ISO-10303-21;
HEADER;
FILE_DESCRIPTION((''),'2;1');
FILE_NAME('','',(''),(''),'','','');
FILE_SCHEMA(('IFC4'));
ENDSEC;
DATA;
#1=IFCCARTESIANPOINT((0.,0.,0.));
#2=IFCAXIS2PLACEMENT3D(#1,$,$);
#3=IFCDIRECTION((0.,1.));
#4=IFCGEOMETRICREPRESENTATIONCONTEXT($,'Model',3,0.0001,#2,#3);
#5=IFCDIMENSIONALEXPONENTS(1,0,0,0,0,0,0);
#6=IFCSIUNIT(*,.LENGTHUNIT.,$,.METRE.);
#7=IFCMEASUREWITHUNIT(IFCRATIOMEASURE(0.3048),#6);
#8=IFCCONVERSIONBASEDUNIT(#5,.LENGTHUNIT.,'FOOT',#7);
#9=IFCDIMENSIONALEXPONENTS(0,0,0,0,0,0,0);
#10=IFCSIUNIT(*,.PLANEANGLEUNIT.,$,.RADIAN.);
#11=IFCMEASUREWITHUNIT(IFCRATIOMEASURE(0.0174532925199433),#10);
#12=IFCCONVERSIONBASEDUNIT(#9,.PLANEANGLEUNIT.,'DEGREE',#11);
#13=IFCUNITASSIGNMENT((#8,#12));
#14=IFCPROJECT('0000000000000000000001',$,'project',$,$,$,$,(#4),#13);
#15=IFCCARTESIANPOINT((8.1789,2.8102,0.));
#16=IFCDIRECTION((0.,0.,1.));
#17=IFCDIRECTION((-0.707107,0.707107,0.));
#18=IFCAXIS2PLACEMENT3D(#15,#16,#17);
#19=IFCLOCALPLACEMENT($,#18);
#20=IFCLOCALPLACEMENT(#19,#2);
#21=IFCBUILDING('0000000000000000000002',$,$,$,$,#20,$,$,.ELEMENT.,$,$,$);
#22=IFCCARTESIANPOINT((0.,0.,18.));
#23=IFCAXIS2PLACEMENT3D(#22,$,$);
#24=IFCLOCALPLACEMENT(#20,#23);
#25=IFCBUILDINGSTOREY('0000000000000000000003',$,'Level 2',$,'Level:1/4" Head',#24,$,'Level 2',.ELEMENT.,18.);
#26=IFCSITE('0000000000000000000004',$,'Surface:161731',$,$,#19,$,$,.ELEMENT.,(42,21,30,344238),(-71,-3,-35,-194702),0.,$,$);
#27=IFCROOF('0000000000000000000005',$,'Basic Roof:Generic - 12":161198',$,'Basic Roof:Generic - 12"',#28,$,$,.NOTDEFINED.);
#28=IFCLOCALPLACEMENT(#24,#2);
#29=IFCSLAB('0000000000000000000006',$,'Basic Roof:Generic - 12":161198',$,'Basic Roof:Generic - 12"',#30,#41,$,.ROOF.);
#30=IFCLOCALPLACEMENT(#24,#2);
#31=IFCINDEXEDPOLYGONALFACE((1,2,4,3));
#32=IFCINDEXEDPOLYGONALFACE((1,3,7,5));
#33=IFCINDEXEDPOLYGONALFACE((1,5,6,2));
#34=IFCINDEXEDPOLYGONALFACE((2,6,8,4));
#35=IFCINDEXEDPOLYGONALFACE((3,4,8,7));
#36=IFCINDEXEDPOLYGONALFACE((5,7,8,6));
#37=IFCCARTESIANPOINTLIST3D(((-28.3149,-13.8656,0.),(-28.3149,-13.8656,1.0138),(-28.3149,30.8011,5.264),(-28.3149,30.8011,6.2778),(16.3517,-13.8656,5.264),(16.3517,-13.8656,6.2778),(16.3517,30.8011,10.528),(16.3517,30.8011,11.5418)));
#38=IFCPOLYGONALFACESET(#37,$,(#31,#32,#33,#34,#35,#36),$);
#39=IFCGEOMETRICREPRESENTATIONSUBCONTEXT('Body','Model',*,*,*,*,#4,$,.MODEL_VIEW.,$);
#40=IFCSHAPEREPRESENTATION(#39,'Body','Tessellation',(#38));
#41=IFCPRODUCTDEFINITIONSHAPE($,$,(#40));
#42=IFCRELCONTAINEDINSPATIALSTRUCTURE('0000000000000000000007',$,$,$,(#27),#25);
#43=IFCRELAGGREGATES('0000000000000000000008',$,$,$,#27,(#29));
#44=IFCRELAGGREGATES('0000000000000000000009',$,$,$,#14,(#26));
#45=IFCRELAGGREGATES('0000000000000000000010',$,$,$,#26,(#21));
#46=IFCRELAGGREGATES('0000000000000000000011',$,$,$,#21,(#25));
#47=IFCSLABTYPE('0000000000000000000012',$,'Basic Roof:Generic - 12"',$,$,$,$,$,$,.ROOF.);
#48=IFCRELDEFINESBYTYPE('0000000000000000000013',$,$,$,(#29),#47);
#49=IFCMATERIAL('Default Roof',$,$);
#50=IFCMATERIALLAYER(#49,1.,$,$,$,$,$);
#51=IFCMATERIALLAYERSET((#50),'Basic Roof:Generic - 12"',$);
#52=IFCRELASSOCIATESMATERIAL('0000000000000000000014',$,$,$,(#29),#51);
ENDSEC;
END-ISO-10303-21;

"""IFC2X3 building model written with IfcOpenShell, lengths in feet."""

from ifc_helpers import new_model, entity, si_unit, converted_unit, direction, frame, origin, place, context, subcontext, project, spatial, polyline, outline, extrude, material, layer, layer_set, type_object, element, aggregate, save


model = new_model("IFC2X3")

# Units and contexts
model_context = context("Model", 3, precision=0.0001, world=origin(), true_north=direction((0.0, 1.0)))
body_context = subcontext(model_context, "Body", "Model", "MODEL_VIEW")
ifc_project = project(units=[converted_unit("LENGTHUNIT", "FOOT", entity("IfcRatioMeasure", 0.3048), si_unit("LENGTHUNIT", "METRE"), dimensions=[1, 0, 0, 0, 0, 0, 0]), converted_unit("PLANEANGLEUNIT", "DEGREE", entity("IfcRatioMeasure", 0.0174532925199433), si_unit("PLANEANGLEUNIT", "RADIAN"), dimensions=[0, 0, 0, 0, 0, 0, 0])], contexts=[model_context])

# Site, building, storey
site_placement = place(None, frame((8.1789, 2.8102, 0.0), z_axis=(0.0, 0.0, 1.0), x_axis=(-0.707107, 0.707107, 0.0)))
site = spatial("IfcSite", under=ifc_project, at=site_placement, Name="Surface:161731", CompositionType="ELEMENT", RefLatitude=(42, 21, 30, 344238), RefLongitude=(-71, -3, -35, -194702), RefElevation=0.0)
building_placement = place(site_placement, origin())
building = spatial("IfcBuilding", under=site, at=building_placement, CompositionType="ELEMENT")
storey_placement = place(building_placement, frame((0.0, 0.0, 18.0)))
storey = spatial("IfcBuildingStorey", under=building, at=storey_placement, Name="Level 2", ObjectType="Level:1/4\" Head", LongName="Level 2", CompositionType="ELEMENT", Elevation=18.0)

# Roof, slab
roof_placement = place(storey_placement, frame((-28.3149, -13.8656, 0.0)))
roof = element("IfcRoof", 1, at=roof_placement, inside=storey, Name="Basic Roof:Generic - 12\":161198", ObjectType="Basic Roof:Generic - 12\"", ShapeType="NOTDEFINED")
ifc_material = material(Name="Default Roof")
ifc_layer = layer(ifc_material, 1.0)
ifc_layer_set = layer_set([ifc_layer], Name="Basic Roof:Generic - 12\"")
slab_type = type_object("IfcSlabType", Name="Basic Roof:Generic - 12\"", PredefinedType="ROOF")
slab_placement = place(roof_placement, origin())
slab = element("IfcSlab", 2, at=slab_placement, type_object=slab_type, material=ifc_layer_set, Name="Basic Roof:Generic - 12\":161198", ObjectType="Basic Roof:Generic - 12\"", PredefinedType="ROOF", context=body_context, shape_type="SweptSolid", body=[
    extrude(outline(polyline([(-22.4858, 22.1798), (-22.4858, -22.7959), (22.4858, -22.1798), (22.4858, 22.7959), (-22.4858, 22.1798)])), frame((22.3333, 22.3333, 5.264), z_axis=(-0.116248, -0.116248, 0.986394), x_axis=(0.99322, -0.013606, 0.115449)), (0.115449, 0.117041, 0.986394), 1.0138),
])
aggregate(roof, [slab])

save(model, "model.ifc")
